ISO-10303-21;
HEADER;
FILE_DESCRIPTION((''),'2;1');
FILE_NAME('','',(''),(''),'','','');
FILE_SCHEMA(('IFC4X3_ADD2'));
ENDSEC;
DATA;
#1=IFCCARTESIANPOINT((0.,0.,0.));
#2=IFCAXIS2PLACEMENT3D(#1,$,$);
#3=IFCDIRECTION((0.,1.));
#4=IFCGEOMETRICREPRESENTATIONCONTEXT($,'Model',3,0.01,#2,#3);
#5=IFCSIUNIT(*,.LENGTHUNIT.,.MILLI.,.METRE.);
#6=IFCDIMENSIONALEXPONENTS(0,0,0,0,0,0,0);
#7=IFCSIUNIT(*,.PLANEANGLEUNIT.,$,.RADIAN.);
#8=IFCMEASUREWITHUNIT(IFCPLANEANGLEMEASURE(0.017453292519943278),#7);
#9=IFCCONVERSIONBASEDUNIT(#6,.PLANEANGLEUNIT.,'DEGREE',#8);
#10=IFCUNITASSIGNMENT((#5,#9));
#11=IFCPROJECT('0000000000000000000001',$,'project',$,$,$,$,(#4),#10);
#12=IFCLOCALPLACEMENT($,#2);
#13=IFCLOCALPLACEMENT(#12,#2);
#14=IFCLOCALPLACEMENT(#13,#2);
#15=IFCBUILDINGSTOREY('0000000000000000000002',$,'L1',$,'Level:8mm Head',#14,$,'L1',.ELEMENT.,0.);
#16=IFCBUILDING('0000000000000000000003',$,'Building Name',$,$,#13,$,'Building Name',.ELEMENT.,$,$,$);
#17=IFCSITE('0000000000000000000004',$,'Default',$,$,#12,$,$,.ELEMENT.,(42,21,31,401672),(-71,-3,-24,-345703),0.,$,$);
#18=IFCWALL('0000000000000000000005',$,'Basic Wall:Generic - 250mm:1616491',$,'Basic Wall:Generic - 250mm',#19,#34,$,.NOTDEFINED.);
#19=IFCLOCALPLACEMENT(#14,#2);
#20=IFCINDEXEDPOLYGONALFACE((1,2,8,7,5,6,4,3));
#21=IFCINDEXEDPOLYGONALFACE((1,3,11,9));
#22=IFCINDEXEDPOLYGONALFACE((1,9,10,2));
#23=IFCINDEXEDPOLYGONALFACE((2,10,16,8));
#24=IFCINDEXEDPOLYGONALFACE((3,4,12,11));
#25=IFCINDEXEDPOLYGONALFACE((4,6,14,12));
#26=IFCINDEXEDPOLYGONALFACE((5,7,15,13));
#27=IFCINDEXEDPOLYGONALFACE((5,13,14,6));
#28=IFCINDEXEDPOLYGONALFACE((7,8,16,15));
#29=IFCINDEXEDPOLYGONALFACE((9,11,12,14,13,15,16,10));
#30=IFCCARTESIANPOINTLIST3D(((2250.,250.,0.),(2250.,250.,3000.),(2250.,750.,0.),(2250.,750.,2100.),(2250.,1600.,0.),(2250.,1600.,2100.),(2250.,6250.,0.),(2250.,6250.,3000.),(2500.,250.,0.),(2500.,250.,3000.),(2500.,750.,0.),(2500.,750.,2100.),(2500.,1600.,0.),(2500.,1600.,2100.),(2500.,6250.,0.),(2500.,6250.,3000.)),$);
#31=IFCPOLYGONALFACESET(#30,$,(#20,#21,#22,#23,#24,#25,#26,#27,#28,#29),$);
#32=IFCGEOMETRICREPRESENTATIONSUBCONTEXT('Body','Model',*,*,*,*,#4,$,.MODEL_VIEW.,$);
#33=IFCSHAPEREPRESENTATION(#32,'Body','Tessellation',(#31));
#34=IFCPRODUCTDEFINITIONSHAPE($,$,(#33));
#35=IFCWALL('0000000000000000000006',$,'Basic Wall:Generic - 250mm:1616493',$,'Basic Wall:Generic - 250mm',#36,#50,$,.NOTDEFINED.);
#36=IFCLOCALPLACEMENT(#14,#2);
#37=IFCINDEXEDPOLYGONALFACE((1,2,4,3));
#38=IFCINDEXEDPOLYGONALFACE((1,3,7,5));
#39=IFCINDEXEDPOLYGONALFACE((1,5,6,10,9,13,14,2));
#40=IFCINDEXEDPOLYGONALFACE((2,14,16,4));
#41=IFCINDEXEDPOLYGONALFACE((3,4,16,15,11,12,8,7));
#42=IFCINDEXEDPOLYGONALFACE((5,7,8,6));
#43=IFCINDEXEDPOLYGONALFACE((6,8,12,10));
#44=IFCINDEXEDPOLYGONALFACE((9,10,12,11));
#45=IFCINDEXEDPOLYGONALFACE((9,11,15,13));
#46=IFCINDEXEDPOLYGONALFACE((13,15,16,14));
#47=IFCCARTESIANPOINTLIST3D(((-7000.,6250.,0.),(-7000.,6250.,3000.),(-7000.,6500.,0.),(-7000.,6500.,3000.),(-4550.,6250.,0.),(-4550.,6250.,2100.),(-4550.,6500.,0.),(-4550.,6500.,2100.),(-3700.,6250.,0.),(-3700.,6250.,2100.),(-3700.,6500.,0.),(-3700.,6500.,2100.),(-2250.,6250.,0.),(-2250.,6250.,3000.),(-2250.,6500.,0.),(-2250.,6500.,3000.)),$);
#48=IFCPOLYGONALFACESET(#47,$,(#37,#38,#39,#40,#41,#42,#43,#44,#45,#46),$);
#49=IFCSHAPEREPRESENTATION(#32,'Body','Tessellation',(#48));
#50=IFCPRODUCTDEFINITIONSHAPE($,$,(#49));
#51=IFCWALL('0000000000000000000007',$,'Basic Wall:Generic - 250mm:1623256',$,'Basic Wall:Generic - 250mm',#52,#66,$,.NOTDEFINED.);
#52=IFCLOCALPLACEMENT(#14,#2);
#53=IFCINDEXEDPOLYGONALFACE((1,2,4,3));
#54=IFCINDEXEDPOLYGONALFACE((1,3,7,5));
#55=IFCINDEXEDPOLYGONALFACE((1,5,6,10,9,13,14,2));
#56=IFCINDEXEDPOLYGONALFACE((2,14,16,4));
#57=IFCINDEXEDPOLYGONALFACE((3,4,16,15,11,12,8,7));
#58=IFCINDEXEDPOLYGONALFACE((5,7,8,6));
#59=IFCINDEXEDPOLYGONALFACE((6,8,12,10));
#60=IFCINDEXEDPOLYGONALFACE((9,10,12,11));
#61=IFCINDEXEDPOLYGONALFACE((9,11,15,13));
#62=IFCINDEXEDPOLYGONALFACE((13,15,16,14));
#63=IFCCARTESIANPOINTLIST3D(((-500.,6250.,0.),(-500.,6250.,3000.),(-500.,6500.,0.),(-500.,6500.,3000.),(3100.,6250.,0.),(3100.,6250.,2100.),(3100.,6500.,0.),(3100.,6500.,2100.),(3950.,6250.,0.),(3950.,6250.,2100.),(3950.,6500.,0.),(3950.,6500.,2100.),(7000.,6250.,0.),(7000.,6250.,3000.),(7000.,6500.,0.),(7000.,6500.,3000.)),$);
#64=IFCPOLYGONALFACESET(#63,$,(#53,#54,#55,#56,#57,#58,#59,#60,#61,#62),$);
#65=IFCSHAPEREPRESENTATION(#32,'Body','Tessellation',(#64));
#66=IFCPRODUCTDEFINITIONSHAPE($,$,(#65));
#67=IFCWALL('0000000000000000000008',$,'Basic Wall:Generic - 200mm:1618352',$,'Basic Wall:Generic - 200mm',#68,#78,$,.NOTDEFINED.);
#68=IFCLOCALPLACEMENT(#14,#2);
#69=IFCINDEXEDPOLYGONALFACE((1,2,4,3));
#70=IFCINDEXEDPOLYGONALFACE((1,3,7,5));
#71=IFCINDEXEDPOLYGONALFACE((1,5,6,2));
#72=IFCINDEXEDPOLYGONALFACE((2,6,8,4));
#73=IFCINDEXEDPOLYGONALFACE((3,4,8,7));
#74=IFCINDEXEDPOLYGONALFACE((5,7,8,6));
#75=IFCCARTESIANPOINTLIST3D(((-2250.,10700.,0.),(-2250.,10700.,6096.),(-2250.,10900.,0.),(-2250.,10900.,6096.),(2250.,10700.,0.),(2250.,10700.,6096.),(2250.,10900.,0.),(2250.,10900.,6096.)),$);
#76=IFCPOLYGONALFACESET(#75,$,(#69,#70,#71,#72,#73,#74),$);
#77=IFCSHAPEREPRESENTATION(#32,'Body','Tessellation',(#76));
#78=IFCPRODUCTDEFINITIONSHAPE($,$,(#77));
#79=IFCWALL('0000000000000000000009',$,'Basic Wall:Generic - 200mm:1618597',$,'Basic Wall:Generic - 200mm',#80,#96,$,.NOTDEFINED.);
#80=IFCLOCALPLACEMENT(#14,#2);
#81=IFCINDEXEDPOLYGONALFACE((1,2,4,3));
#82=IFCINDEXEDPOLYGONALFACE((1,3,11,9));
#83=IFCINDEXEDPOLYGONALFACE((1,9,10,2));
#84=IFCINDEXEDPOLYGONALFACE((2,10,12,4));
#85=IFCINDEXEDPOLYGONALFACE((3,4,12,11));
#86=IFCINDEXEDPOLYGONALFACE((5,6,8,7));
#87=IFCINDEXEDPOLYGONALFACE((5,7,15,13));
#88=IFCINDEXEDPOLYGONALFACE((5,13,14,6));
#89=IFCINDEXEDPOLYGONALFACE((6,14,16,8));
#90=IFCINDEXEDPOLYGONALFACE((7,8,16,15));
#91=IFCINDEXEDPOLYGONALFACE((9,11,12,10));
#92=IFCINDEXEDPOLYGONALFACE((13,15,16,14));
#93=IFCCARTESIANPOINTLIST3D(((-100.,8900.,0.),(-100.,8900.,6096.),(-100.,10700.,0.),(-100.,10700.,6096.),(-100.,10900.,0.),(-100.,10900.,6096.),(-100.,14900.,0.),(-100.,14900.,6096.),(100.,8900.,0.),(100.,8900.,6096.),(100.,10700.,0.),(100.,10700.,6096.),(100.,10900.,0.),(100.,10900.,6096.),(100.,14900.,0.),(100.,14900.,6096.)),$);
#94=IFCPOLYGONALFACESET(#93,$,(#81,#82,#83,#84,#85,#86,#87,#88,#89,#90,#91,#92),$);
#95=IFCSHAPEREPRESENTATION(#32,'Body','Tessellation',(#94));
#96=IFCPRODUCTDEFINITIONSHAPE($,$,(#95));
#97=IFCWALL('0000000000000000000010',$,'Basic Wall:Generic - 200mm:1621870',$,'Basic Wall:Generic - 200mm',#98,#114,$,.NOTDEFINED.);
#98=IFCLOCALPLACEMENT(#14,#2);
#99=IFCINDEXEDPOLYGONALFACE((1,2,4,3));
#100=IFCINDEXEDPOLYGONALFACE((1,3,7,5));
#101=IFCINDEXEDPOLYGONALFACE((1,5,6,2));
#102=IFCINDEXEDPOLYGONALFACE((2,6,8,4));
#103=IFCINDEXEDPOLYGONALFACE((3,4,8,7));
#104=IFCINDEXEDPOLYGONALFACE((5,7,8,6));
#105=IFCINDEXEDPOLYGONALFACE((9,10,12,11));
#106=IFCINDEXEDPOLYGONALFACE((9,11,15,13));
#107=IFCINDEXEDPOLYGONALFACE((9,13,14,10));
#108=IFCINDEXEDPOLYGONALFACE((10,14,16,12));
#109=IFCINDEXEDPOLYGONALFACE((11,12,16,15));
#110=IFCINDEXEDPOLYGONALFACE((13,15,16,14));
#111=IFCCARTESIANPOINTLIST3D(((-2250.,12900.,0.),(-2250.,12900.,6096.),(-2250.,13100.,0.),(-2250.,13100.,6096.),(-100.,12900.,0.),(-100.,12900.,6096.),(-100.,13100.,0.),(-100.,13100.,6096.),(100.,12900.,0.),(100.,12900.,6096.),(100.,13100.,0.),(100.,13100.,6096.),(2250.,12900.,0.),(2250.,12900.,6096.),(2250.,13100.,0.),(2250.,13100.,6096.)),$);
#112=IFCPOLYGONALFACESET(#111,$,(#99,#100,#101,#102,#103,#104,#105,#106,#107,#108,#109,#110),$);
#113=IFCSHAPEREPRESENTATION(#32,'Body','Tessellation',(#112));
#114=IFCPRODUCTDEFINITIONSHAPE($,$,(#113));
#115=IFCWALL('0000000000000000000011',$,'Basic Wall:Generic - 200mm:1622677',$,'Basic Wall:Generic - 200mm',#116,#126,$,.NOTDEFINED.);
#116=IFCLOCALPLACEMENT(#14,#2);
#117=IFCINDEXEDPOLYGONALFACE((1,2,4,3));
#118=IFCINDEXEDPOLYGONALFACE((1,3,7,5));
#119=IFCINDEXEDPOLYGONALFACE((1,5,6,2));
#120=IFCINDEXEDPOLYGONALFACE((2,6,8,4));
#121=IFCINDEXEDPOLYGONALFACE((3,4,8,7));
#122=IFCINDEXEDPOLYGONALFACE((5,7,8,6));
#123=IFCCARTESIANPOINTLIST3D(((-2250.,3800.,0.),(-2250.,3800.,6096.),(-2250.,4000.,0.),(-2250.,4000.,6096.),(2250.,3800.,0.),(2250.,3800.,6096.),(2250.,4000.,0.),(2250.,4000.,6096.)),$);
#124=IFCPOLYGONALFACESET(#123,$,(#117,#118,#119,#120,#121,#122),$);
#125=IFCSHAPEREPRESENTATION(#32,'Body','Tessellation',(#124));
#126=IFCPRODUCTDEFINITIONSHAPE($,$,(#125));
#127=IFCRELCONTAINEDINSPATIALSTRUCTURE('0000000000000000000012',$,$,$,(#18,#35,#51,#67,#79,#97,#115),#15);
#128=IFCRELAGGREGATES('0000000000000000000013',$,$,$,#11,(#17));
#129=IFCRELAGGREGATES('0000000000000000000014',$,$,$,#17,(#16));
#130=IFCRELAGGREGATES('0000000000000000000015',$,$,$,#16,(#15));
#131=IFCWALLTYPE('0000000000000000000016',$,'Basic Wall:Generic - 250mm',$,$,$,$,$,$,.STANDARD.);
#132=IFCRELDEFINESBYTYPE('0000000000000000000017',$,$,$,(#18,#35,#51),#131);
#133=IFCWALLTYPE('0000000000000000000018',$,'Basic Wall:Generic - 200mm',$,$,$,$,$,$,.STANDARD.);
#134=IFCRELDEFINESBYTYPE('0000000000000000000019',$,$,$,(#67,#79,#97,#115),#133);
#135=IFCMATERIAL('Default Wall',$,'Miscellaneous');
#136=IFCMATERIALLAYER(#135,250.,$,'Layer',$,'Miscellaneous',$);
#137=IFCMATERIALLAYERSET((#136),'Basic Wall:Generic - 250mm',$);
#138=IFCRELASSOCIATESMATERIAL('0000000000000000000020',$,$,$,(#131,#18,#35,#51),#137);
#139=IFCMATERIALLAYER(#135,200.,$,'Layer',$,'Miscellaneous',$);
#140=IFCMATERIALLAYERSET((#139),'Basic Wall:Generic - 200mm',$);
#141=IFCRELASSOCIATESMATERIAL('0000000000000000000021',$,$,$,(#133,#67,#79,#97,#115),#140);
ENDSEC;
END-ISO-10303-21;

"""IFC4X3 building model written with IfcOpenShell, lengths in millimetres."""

from ifc_helpers import new_model, entity, si_unit, converted_unit, direction, frame, frame_2d, origin, place, context, subcontext, project, spatial, rectangle, extrude, material, layer, layer_set, type_object, element, save


model = new_model("IFC4X3")

# Units and contexts
model_context = context("Model", 3, precision=0.01, world=origin(), true_north=direction((0.0, 1.0)))
body_context = subcontext(model_context, "Body", "Model", "MODEL_VIEW")
ifc_project = project(units=[si_unit("LENGTHUNIT", "METRE", prefix="MILLI"), converted_unit("PLANEANGLEUNIT", "DEGREE", entity("IfcPlaneAngleMeasure", 0.017453292519943278), si_unit("PLANEANGLEUNIT", "RADIAN"), dimensions=[0, 0, 0, 0, 0, 0, 0])], contexts=[model_context])

# Site, building, storey
site_placement = place(None, origin())
site = spatial("IfcSite", under=ifc_project, at=site_placement, Name="Default", CompositionType="ELEMENT", RefLatitude=(42, 21, 31, 401672), RefLongitude=(-71, -3, -24, -345703), RefElevation=0.0)
building_placement = place(site_placement, origin())
building = spatial("IfcBuilding", under=site, at=building_placement, Name="Building Name", LongName="Building Name", CompositionType="ELEMENT")
storey_placement = place(building_placement, origin())
storey = spatial("IfcBuildingStorey", under=building, at=storey_placement, Name="L1", ObjectType="Level:8mm Head", LongName="L1", CompositionType="ELEMENT", Elevation=0.0)

# Shared definitions
ifc_material = material(Name="Default Wall", Category="Miscellaneous")
ifc_layer_1 = layer(ifc_material, 250.0, Name="Layer", Category="Miscellaneous")
ifc_layer_set_1 = layer_set([ifc_layer_1], Name="Basic Wall:Generic - 250mm")
wall_type_1 = type_object("IfcWallType", Name="Basic Wall:Generic - 250mm", PredefinedType="STANDARD", material=ifc_layer_set_1)

# Walls, openings
wall_1_placement = place(storey_placement, frame((2375.0, 250.0, 0.0), z_axis=(0.0, 0.0, 1.0), x_axis=(0.0, 1.0, 0.0)))
wall_1 = element("IfcWall", 1, at=wall_1_placement, inside=storey, type_object=wall_type_1, material=ifc_layer_set_1, Name="Basic Wall:Generic - 250mm:1616491", ObjectType="Basic Wall:Generic - 250mm", PredefinedType="NOTDEFINED", context=body_context, shape_type="SweptSolid", body=[
    extrude(rectangle(XDim=6000.0, YDim=250.0, at=frame_2d((3000.0, 0.0), x_axis=(-1.0, 0.0))), origin(), (0.0, 0.0, 1.0), 3000.0),
])
opening_1_placement = place(wall_1_placement, frame((500.0, -125.0, 0.0)))
element("IfcOpeningElement", 2, at=opening_1_placement, cuts=wall_1, PredefinedType="OPENING", context=body_context, shape_type="SweptSolid", body=[
    extrude(rectangle(XDim=2100.0, YDim=850.0, at=frame_2d((1050.0, 425.0), x_axis=(1.0, 0.0))), frame((0.0, 0.0, 0.0), z_axis=(0.0, 1.0, 0.0), x_axis=(0.0, 0.0, 1.0)), (0.0, 0.0, 1.0), 250.0),
])
wall_2_placement = place(storey_placement, frame((-7000.0, 6375.0, 0.0)))
wall_2 = element("IfcWall", 3, at=wall_2_placement, inside=storey, type_object=wall_type_1, material=ifc_layer_set_1, Name="Basic Wall:Generic - 250mm:1616493", ObjectType="Basic Wall:Generic - 250mm", PredefinedType="NOTDEFINED", context=body_context, shape_type="SweptSolid", body=[
    extrude(rectangle(XDim=4750.0, YDim=250.0, at=frame_2d((2375.0, 0.0), x_axis=(1.0, 0.0))), origin(), (0.0, 0.0, 1.0), 3000.0),
])
opening_2_placement = place(wall_2_placement, frame((3300.0, 125.0, 0.0)))
element("IfcOpeningElement", 4, at=opening_2_placement, cuts=wall_2, PredefinedType="OPENING", context=body_context, shape_type="SweptSolid", body=[
    extrude(rectangle(XDim=2100.0, YDim=850.0, at=frame_2d((1050.0, 425.0), x_axis=(1.0, 0.0))), frame((0.0, 0.0, 0.0), z_axis=(0.0, -1.0, 0.0), x_axis=(0.0, 0.0, 1.0)), (0.0, 0.0, 1.0), 250.0),
])

# Wall, openings
wall_3_placement = place(storey_placement, frame((-500.0, 6375.0, 0.0)))
wall_3 = element("IfcWall", 5, at=wall_3_placement, inside=storey, type_object=wall_type_1, material=ifc_layer_set_1, Name="Basic Wall:Generic - 250mm:1623256", ObjectType="Basic Wall:Generic - 250mm", PredefinedType="NOTDEFINED", context=body_context, shape_type="SweptSolid", body=[
    extrude(rectangle(XDim=7500.0, YDim=250.0, at=frame_2d((3750.0, 0.0), x_axis=(1.0, 0.0))), origin(), (0.0, 0.0, 1.0), 3000.0),
])
opening_3_placement = place(wall_3_placement, frame((4450.0, 125.0, 0.0)))
element("IfcOpeningElement", 6, at=opening_3_placement, cuts=wall_3, PredefinedType="OPENING", context=body_context, shape_type="SweptSolid", body=[
    extrude(rectangle(XDim=2100.0, YDim=850.0, at=frame_2d((1050.0, 425.0), x_axis=(1.0, 0.0))), frame((0.0, 0.0, 0.0), z_axis=(0.0, -1.0, 0.0), x_axis=(0.0, 0.0, 1.0)), (0.0, 0.0, 1.0), 250.0),
])
opening_4_placement = place(wall_3_placement, frame((500.0, -6375.0, 0.0)))
element("IfcOpeningElement", 7, at=opening_4_placement, cuts=wall_3, PredefinedType="OPENING", context=body_context, shape_type="SweptSolid", body=[
    extrude(rectangle(XDim=2100.0, YDim=850.0, at=frame_2d((0.0, 0.0), x_axis=(1.0, 0.0))), frame((3525.0, 4976.0, 1050.0), z_axis=(0.0, 1.0, 0.0), x_axis=(0.0, 0.0, 1.0)), (0.0, 0.0, 1.0), 3048.0),
])

# Wall
ifc_layer_2 = layer(ifc_material, 200.0, Name="Layer", Category="Miscellaneous")
ifc_layer_set_2 = layer_set([ifc_layer_2], Name="Basic Wall:Generic - 200mm")
wall_type_2 = type_object("IfcWallType", Name="Basic Wall:Generic - 200mm", PredefinedType="STANDARD", material=ifc_layer_set_2)
wall_4_placement = place(storey_placement, frame((-2250.0, 10800.0, 0.0)))
element("IfcWall", 8, at=wall_4_placement, inside=storey, type_object=wall_type_2, material=ifc_layer_set_2, Name="Basic Wall:Generic - 200mm:1618352", ObjectType="Basic Wall:Generic - 200mm", PredefinedType="NOTDEFINED", context=body_context, shape_type="SweptSolid", body=[
    extrude(rectangle(XDim=4500.0, YDim=200.0, at=frame_2d((2250.0, 0.0), x_axis=(-1.0, 0.0))), origin(), (0.0, 0.0, 1.0), 6096.0),
])

# Walls, openings
wall_5_placement = place(storey_placement, frame((0.0, 8900.0, 0.0), z_axis=(0.0, 0.0, 1.0), x_axis=(0.0, 1.0, 0.0)))
wall_5 = element("IfcWall", 9, at=wall_5_placement, inside=storey, type_object=wall_type_2, material=ifc_layer_set_2, Name="Basic Wall:Generic - 200mm:1618597", ObjectType="Basic Wall:Generic - 200mm", PredefinedType="NOTDEFINED", context=body_context, shape_type="SweptSolid", body=[
    extrude(rectangle(XDim=6000.0, YDim=200.0, at=frame_2d((3000.0, 0.0), x_axis=(-1.0, 0.0))), origin(), (0.0, 0.0, 1.0), 6096.0),
])
opening_5_placement = place(storey_placement, frame((0.0, 8900.0, 0.0), z_axis=(0.0, 0.0, 1.0), x_axis=(0.0, 1.0, 0.0)))
element("IfcOpeningElement", 10, at=opening_5_placement, cuts=wall_5, PredefinedType="OPENING", context=body_context, shape_type="SweptSolid", body=[
    extrude(rectangle(XDim=6096.0, YDim=200.0, at=frame_2d((0.0, 0.0), x_axis=(1.0, 0.0))), frame((1800.0, 0.0, 3048.0), z_axis=(1.0, 0.0, 0.0), x_axis=(0.0, 0.0, -1.0)), (0.0, 0.0, 1.0), 200.0),
])
wall_6_placement = place(storey_placement, frame((-2250.0, 13000.0, 0.0)))
wall_6 = element("IfcWall", 11, at=wall_6_placement, inside=storey, type_object=wall_type_2, material=ifc_layer_set_2, Name="Basic Wall:Generic - 200mm:1621870", ObjectType="Basic Wall:Generic - 200mm", PredefinedType="NOTDEFINED", context=body_context, shape_type="SweptSolid", body=[
    extrude(rectangle(XDim=4500.0, YDim=200.0, at=frame_2d((2250.0, 0.0), x_axis=(-1.0, 0.0))), origin(), (0.0, 0.0, 1.0), 6096.0),
])
opening_6_placement = place(storey_placement, frame((-2250.0, 13000.0, 0.0)))
element("IfcOpeningElement", 12, at=opening_6_placement, cuts=wall_6, PredefinedType="OPENING", context=body_context, shape_type="SweptSolid", body=[
    extrude(rectangle(XDim=6096.0, YDim=200.0, at=frame_2d((0.0, 0.0), x_axis=(1.0, 0.0))), frame((2150.0, 0.0, 3048.0), z_axis=(1.0, 0.0, 0.0), x_axis=(0.0, 0.0, -1.0)), (0.0, 0.0, 1.0), 200.0),
])

# Wall
wall_7_placement = place(storey_placement, frame((-2250.0, 3900.0, 0.0)))
element("IfcWall", 13, at=wall_7_placement, inside=storey, type_object=wall_type_2, material=ifc_layer_set_2, Name="Basic Wall:Generic - 200mm:1622677", ObjectType="Basic Wall:Generic - 200mm", PredefinedType="NOTDEFINED", context=body_context, shape_type="SweptSolid", body=[
    extrude(rectangle(XDim=4500.0, YDim=200.0, at=frame_2d((2250.0, 0.0), x_axis=(-1.0, 0.0))), origin(), (0.0, 0.0, 1.0), 6096.0),
])

save(model, "model.ifc")
